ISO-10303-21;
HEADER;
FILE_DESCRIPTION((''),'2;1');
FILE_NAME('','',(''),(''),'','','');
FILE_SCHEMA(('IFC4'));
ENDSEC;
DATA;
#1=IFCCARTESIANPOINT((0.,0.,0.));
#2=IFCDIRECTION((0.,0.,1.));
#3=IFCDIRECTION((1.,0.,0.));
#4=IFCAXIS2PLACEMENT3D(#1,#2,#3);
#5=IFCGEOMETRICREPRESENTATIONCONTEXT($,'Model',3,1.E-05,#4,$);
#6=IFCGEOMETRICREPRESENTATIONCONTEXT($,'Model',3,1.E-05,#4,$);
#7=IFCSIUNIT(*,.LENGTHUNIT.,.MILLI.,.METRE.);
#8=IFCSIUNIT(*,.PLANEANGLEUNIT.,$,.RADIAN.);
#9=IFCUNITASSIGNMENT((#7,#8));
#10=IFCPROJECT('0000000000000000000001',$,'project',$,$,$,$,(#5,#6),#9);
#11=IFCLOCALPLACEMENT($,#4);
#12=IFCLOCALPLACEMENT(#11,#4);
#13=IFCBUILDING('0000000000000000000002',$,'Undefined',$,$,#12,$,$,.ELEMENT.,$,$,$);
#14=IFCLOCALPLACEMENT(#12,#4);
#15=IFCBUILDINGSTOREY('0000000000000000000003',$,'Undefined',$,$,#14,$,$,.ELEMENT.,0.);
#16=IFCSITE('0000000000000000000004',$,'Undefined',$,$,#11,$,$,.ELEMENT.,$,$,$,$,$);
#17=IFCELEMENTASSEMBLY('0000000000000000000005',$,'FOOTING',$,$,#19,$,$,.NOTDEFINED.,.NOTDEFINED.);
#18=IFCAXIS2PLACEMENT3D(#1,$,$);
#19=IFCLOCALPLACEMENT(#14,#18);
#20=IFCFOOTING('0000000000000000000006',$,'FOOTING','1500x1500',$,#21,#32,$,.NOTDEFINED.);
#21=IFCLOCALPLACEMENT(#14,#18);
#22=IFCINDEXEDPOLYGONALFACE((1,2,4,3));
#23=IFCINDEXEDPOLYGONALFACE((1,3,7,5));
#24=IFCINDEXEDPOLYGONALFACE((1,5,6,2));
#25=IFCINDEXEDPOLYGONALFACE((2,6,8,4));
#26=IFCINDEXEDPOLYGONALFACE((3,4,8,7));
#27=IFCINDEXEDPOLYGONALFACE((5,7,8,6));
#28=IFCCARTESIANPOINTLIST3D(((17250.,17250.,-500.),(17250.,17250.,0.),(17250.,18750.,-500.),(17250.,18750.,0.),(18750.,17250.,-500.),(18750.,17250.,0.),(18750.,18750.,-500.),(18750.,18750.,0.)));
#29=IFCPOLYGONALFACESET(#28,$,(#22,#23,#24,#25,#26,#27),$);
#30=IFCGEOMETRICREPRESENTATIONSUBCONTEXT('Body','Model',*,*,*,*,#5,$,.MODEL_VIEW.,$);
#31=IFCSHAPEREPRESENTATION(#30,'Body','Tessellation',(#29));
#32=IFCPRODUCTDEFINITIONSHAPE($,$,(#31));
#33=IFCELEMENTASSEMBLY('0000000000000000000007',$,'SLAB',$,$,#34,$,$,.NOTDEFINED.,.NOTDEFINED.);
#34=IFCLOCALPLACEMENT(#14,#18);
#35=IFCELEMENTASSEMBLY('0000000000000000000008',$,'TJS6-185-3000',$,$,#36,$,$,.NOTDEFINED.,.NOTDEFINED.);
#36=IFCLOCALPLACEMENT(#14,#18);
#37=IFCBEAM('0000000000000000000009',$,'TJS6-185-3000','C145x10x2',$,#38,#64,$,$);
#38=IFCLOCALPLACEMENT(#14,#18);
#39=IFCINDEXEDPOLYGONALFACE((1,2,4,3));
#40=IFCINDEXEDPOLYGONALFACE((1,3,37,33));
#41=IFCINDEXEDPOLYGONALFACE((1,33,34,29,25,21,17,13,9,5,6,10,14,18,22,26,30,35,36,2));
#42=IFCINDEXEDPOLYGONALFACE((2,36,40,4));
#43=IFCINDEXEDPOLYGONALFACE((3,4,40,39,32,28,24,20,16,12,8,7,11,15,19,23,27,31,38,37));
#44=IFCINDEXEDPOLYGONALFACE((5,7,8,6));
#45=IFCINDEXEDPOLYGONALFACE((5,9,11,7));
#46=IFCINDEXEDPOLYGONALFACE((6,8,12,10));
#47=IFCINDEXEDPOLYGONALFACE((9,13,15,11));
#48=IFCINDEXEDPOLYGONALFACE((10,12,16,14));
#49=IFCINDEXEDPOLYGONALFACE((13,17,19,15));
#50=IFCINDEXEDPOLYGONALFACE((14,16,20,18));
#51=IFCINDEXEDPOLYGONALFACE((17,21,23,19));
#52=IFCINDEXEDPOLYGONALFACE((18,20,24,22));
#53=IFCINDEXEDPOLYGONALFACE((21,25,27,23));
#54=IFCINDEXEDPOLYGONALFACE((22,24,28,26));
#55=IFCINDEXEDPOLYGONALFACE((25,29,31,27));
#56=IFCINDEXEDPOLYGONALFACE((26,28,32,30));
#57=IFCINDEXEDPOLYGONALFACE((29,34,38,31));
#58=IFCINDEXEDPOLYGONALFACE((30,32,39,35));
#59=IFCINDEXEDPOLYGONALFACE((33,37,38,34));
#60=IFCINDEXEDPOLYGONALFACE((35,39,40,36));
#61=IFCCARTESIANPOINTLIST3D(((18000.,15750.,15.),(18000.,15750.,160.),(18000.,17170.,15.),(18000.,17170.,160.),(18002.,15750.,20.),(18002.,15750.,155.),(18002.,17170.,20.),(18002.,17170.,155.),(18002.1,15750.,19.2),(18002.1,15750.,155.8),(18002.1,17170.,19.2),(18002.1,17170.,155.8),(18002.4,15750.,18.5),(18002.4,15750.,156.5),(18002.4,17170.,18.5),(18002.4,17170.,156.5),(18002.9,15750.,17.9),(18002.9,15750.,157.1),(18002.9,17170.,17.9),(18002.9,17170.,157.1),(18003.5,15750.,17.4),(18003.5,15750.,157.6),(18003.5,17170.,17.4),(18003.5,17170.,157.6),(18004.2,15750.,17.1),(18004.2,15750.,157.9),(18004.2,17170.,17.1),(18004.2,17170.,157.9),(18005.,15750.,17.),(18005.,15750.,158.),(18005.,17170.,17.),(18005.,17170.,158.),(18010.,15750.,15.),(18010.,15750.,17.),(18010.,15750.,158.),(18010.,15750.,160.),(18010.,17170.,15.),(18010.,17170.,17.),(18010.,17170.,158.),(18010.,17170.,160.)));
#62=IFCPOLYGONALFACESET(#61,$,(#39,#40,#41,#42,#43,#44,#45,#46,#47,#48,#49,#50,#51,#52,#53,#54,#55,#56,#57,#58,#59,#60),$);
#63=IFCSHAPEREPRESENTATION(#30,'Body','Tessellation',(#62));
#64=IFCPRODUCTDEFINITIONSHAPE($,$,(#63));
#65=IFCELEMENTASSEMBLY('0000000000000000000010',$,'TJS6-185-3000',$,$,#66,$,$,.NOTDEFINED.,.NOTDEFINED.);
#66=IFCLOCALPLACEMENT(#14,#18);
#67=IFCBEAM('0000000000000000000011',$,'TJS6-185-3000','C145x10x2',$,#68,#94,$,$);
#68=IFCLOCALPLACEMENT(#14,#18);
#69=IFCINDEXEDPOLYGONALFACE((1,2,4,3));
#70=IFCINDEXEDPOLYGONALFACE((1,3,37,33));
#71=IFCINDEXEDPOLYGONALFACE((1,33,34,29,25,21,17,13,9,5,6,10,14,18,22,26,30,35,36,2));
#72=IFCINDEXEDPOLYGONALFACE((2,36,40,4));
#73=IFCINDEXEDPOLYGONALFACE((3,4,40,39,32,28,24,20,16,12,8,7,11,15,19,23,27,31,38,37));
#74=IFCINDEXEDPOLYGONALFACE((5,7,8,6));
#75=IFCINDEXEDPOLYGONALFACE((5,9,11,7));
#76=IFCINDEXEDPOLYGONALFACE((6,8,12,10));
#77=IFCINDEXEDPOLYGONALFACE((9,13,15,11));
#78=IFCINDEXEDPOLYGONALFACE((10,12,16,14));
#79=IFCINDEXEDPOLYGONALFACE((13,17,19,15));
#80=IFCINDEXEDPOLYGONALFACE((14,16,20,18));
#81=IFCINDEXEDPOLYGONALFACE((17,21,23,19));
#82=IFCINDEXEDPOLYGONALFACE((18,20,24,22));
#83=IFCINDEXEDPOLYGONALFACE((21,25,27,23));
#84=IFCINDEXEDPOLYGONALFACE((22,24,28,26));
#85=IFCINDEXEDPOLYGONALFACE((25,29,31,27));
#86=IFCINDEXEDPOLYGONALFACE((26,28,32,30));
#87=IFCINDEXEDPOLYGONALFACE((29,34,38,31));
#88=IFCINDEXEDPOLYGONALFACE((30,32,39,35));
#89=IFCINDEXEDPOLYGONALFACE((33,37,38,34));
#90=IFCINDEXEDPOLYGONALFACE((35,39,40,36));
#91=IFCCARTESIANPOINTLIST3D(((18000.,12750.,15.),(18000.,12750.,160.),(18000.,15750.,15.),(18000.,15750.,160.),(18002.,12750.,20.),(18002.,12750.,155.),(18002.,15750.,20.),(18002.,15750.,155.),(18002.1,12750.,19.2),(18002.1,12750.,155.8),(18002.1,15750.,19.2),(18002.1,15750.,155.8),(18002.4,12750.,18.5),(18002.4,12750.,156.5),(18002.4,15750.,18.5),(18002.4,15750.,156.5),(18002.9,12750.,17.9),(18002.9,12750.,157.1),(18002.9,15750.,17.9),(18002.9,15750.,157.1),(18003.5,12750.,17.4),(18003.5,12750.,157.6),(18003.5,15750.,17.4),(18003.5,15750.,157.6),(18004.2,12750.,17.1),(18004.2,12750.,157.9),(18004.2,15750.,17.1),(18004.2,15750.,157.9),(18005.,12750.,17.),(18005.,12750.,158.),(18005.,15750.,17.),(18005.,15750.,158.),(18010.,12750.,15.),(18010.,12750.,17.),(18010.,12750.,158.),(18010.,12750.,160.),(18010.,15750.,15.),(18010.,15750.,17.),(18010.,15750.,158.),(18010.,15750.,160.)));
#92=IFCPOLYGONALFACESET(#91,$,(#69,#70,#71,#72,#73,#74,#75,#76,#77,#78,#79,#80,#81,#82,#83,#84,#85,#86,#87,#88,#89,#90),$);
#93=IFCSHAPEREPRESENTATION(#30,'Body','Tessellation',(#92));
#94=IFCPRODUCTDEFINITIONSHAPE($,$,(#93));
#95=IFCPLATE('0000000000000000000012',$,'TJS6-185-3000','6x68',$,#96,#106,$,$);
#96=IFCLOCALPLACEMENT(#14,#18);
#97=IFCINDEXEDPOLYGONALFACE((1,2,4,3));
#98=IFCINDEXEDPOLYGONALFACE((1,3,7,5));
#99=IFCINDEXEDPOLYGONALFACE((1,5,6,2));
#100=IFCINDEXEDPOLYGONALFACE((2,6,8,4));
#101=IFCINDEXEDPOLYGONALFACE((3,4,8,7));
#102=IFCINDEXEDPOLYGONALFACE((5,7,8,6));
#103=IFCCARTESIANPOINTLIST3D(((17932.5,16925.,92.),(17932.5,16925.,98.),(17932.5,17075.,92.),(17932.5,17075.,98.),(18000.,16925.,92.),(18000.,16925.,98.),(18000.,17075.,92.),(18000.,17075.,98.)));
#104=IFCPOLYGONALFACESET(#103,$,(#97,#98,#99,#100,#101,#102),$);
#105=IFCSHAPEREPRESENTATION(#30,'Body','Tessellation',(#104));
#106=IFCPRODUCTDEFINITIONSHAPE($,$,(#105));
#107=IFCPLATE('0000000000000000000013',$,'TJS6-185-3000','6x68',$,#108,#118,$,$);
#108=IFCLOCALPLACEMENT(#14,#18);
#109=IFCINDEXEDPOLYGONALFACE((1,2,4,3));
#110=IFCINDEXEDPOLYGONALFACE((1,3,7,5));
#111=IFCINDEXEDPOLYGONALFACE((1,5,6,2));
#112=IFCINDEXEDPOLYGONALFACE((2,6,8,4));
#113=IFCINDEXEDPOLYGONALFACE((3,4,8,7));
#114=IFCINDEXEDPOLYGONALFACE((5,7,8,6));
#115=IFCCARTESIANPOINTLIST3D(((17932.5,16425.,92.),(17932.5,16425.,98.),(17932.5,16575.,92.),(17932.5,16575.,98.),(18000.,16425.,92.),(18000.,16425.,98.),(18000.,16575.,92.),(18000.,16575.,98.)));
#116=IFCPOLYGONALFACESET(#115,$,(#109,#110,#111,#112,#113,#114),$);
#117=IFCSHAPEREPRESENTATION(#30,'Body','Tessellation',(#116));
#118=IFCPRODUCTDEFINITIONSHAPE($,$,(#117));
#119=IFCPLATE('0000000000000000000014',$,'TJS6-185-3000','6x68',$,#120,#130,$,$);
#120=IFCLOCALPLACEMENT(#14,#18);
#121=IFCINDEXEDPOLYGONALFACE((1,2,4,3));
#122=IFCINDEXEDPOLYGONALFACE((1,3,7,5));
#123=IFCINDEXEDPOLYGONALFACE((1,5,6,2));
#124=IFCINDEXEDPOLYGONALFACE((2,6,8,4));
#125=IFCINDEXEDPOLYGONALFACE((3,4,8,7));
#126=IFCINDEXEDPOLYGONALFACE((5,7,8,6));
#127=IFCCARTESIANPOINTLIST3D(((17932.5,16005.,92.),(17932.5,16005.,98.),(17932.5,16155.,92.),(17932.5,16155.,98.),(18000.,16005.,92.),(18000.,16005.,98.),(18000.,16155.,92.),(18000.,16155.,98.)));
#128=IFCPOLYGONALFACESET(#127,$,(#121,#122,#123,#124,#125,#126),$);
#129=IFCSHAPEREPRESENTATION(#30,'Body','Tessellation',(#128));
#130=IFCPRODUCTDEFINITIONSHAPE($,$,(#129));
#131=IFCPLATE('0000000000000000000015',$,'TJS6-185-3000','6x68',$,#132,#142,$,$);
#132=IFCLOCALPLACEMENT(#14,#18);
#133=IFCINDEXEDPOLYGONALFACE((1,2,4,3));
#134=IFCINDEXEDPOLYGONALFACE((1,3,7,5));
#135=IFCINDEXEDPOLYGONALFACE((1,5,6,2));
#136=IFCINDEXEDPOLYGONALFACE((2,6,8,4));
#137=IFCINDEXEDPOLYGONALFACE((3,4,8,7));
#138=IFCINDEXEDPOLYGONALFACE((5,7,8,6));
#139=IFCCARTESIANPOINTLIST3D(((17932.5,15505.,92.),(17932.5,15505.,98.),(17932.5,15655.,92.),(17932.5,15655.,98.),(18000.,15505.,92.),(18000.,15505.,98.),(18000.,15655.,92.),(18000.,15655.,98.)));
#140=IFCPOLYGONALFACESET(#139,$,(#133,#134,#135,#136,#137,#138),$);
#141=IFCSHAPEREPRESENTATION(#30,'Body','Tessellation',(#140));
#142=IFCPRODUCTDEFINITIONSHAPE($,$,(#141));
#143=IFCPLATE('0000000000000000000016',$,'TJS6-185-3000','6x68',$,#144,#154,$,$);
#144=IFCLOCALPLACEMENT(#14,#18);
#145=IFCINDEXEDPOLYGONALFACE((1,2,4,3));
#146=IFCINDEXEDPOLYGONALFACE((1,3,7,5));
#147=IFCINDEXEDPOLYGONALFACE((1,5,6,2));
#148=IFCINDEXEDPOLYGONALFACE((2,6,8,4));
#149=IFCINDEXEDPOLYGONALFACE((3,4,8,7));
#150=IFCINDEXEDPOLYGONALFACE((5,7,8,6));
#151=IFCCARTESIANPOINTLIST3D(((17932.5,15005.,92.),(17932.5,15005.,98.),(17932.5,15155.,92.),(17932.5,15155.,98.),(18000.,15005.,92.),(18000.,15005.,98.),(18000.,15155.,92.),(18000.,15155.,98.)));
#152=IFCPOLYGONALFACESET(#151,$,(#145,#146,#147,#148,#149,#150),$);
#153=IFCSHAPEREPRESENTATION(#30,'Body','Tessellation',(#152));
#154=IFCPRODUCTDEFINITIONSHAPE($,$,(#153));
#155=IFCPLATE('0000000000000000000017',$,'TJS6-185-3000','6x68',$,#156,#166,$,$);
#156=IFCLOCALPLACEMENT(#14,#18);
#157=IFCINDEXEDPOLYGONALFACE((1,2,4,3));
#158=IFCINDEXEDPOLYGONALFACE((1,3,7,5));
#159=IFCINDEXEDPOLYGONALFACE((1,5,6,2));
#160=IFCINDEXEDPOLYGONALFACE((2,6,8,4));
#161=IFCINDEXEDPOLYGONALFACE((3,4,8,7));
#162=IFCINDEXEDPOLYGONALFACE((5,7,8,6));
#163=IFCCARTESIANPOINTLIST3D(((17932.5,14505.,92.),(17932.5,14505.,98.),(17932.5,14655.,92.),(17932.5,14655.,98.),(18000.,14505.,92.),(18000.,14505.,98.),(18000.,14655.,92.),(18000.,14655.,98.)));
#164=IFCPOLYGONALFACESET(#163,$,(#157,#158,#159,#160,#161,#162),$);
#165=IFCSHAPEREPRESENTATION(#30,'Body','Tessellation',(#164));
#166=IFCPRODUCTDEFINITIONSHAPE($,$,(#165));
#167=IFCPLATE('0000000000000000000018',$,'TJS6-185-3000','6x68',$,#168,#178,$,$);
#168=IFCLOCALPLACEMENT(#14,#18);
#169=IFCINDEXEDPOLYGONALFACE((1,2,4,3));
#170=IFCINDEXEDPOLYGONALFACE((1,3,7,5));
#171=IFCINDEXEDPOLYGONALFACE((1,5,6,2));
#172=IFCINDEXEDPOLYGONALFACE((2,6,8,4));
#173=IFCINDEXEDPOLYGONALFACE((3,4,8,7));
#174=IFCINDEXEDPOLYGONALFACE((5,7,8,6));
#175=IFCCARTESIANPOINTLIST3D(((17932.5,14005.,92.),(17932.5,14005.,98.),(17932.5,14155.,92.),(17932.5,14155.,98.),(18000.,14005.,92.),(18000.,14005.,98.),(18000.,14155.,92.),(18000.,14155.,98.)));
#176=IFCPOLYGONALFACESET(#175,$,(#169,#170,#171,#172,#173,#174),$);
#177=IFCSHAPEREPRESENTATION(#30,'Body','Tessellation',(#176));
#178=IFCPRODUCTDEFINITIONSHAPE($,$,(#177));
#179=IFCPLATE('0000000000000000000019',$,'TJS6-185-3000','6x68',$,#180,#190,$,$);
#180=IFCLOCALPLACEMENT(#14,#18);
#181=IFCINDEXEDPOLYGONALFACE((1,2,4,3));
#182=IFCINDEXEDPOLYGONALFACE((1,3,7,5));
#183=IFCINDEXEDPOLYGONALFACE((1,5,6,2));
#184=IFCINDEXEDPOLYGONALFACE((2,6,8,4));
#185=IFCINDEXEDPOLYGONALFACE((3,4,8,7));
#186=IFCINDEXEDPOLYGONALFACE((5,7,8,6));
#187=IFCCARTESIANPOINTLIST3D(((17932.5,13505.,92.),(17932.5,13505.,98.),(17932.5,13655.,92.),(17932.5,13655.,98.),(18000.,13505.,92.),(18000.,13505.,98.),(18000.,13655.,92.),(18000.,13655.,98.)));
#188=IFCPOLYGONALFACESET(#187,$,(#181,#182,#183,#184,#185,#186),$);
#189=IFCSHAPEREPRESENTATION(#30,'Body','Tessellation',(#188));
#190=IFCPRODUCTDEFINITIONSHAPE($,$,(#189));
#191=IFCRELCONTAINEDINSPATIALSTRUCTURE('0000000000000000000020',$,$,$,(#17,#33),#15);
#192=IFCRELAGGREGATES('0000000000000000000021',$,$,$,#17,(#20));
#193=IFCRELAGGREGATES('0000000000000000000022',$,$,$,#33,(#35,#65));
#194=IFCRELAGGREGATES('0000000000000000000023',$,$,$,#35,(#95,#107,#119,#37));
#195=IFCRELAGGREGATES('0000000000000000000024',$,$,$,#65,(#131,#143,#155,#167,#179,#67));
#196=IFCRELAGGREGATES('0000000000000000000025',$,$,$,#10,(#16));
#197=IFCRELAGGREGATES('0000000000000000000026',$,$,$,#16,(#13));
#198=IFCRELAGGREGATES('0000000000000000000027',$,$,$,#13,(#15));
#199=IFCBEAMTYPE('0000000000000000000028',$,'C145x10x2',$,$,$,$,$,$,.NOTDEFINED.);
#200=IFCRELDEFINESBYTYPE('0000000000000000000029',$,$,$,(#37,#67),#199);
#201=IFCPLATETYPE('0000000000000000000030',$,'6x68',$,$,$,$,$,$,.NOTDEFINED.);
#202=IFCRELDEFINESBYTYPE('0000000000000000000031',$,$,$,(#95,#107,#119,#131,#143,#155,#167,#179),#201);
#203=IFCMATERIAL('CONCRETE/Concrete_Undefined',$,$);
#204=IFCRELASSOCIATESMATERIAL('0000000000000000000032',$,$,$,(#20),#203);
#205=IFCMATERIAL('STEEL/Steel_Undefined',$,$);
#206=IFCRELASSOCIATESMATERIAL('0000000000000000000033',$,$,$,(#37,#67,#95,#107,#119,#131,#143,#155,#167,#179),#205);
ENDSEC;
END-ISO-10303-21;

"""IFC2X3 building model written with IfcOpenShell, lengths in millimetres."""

from ifc_helpers import new_model, si_unit, frame, origin_with_axes, origin_2d_with_axis, place, context, subcontext, project, spatial, polyline, rectangle, u_section, outline, extrude, material, type_object, element, aggregate, save


model = new_model("IFC2X3")

# Units and contexts
model_context_1 = context("Model", 3, precision=1e-05, world=origin_with_axes())
model_context_2 = context("Model", 3, precision=1e-05, world=origin_with_axes())
body_context = subcontext(model_context_1, "Body", "Model", "MODEL_VIEW")
ifc_project = project(units=[si_unit("LENGTHUNIT", "METRE", prefix="MILLI"), si_unit("PLANEANGLEUNIT", "RADIAN")], contexts=[model_context_1, model_context_2])

# Site, building, storey
site_placement = place(None, origin_with_axes())
site = spatial("IfcSite", under=ifc_project, at=site_placement, Name="Undefined", CompositionType="ELEMENT")
building_placement = place(site_placement, origin_with_axes())
building = spatial("IfcBuilding", under=site, at=building_placement, Name="Undefined", CompositionType="ELEMENT")
storey_placement = place(building_placement, origin_with_axes())
storey = spatial("IfcBuildingStorey", under=building, at=storey_placement, Name="Undefined", CompositionType="ELEMENT", Elevation=0.0)

# Element assembly, footing
assembly_1_placement = place(storey_placement, origin_with_axes())
assembly_1 = element("IfcElementAssembly", 1, at=assembly_1_placement, inside=storey, Name="FOOTING", AssemblyPlace="NOTDEFINED", PredefinedType="NOTDEFINED")
ifc_material_1 = material(Name="CONCRETE/Concrete_Undefined")
footing_placement = place(assembly_1_placement, frame((18000.0, 18000.0, -500.0), z_axis=(0.0, 1.0, 0.0), x_axis=(0.0, 0.0, 1.0)))
footing = element("IfcFooting", 2, at=footing_placement, material=ifc_material_1, Name="FOOTING", Description="1500x1500", PredefinedType="NOTDEFINED", context=body_context, shape_type="SweptSolid", body=[
    extrude(rectangle(XDim=1500.0, YDim=1500.0, at=origin_2d_with_axis()), frame((500.0, 0.0, 0.0), z_axis=(-1.0, 0.0, 0.0), x_axis=(0.0, -1.0, 0.0)), (0.0, 0.0, 1.0), 500.0),
])
aggregate(assembly_1, [footing])

# Element assemblies, beams, plates
assembly_2_placement = place(storey_placement, origin_with_axes())
assembly_2 = element("IfcElementAssembly", 3, at=assembly_2_placement, inside=storey, Name="SLAB", AssemblyPlace="NOTDEFINED", PredefinedType="NOTDEFINED")
assembly_3_placement = place(assembly_2_placement, origin_with_axes())
assembly_3 = element("IfcElementAssembly", 4, at=assembly_3_placement, Name="TJS6-185-3000", AssemblyPlace="NOTDEFINED", PredefinedType="NOTDEFINED")
ifc_material_2 = material(Name="STEEL/Steel_Undefined")
beam_type = type_object("IfcBeamType", Name="C145x10x2", PredefinedType="NOTDEFINED")
beam_1_placement = place(assembly_3_placement, frame((18005.0, 15750.0, 87.5), z_axis=(0.0, 0.0, 1.0), x_axis=(0.0, 1.0, 0.0)))
beam_1 = element("IfcBeam", 5, at=beam_1_placement, type_object=beam_type, material=ifc_material_2, Name="TJS6-185-3000", Description="C145x10x2", context=body_context, shape_type="SweptSolid", body=[
    extrude(u_section(Depth=145.0, FlangeWidth=10.0, WebThickness=2.0, FlangeThickness=2.0, FilletRadius=3.0, at=origin_2d_with_axis()), frame((1420.0, 0.0, 0.0), z_axis=(-1.0, 0.0, 0.0), x_axis=(0.0, -1.0, 0.0)), (0.0, 0.0, 1.0), 1420.0),
])
assembly_4_placement = place(assembly_2_placement, origin_with_axes())
assembly_4 = element("IfcElementAssembly", 6, at=assembly_4_placement, Name="TJS6-185-3000", AssemblyPlace="NOTDEFINED", PredefinedType="NOTDEFINED")
beam_2_placement = place(assembly_4_placement, frame((18005.0, 12750.0, 87.5), z_axis=(0.0, 0.0, 1.0), x_axis=(0.0, 1.0, 0.0)))
beam_2 = element("IfcBeam", 7, at=beam_2_placement, type_object=beam_type, material=ifc_material_2, Name="TJS6-185-3000", Description="C145x10x2", context=body_context, shape_type="SweptSolid", body=[
    extrude(u_section(Depth=145.0, FlangeWidth=10.0, WebThickness=2.0, FlangeThickness=2.0, FilletRadius=3.0, at=origin_2d_with_axis()), frame((3000.0, 0.0, 0.0), z_axis=(-1.0, 0.0, 0.0), x_axis=(0.0, -1.0, 0.0)), (0.0, 0.0, 1.0), 3000.0),
])
plate_type_1 = type_object("IfcPlateType", Name="6x68", PredefinedType="NOTDEFINED")
plate_1_placement = place(assembly_3_placement, frame((18000.0, 16925.0, 95.0), z_axis=(0.0, 0.0, 1.0), x_axis=(0.0, 1.0, 0.0)))
plate_1 = element("IfcPlate", 8, at=plate_1_placement, type_object=plate_type_1, material=ifc_material_2, Name="TJS6-185-3000", Description="6x68", context=body_context, shape_type="SweptSolid", body=[
    extrude(outline(polyline([(0.0, 0.0), (150.0, 0.0), (150.0, 67.5), (0.0, 67.5), (0.0, 0.0)])), frame((0.0, 0.0, -3.0), z_axis=(0.0, 0.0, 1.0), x_axis=(1.0, 0.0, 0.0)), (0.0, 0.0, 1.0), 6.0),
])
plate_2_placement = place(assembly_3_placement, frame((18000.0, 16425.0, 95.0), z_axis=(0.0, 0.0, 1.0), x_axis=(0.0, 1.0, 0.0)))
plate_2 = element("IfcPlate", 9, at=plate_2_placement, type_object=plate_type_1, material=ifc_material_2, Name="TJS6-185-3000", Description="6x68", context=body_context, shape_type="SweptSolid", body=[
    extrude(outline(polyline([(0.0, 0.0), (150.0, 0.0), (150.0, 67.5), (0.0, 67.5), (0.0, 0.0)])), frame((0.0, 0.0, -3.0), z_axis=(0.0, 0.0, 1.0), x_axis=(1.0, 0.0, 0.0)), (0.0, 0.0, 1.0), 6.0),
])
plate_3_placement = place(assembly_3_placement, frame((18000.0, 16005.0, 95.0), z_axis=(0.0, 0.0, 1.0), x_axis=(0.0, 1.0, 0.0)))
plate_3 = element("IfcPlate", 10, at=plate_3_placement, type_object=plate_type_1, material=ifc_material_2, Name="TJS6-185-3000", Description="6x68", context=body_context, shape_type="SweptSolid", body=[
    extrude(outline(polyline([(0.0, 0.0), (150.0, 0.0), (150.0, 67.5), (0.0, 67.5), (0.0, 0.0)])), frame((0.0, 0.0, -3.0), z_axis=(0.0, 0.0, 1.0), x_axis=(1.0, 0.0, 0.0)), (0.0, 0.0, 1.0), 6.0),
])
plate_4_placement = place(assembly_4_placement, frame((18000.0, 15505.0, 95.0), z_axis=(0.0, 0.0, 1.0), x_axis=(0.0, 1.0, 0.0)))
plate_4 = element("IfcPlate", 11, at=plate_4_placement, type_object=plate_type_1, material=ifc_material_2, Name="TJS6-185-3000", Description="6x68", context=body_context, shape_type="SweptSolid", body=[
    extrude(outline(polyline([(0.0, 0.0), (150.0, 0.0), (150.0, 67.5), (0.0, 67.5), (0.0, 0.0)])), frame((0.0, 0.0, -3.0), z_axis=(0.0, 0.0, 1.0), x_axis=(1.0, 0.0, 0.0)), (0.0, 0.0, 1.0), 6.0),
])
plate_5_placement = place(assembly_4_placement, frame((18000.0, 15005.0, 95.0), z_axis=(0.0, 0.0, 1.0), x_axis=(0.0, 1.0, 0.0)))
plate_5 = element("IfcPlate", 12, at=plate_5_placement, type_object=plate_type_1, material=ifc_material_2, Name="TJS6-185-3000", Description="6x68", context=body_context, shape_type="SweptSolid", body=[
    extrude(outline(polyline([(0.0, 0.0), (150.0, 0.0), (150.0, 67.5), (0.0, 67.5), (0.0, 0.0)])), frame((0.0, 0.0, -3.0), z_axis=(0.0, 0.0, 1.0), x_axis=(1.0, 0.0, 0.0)), (0.0, 0.0, 1.0), 6.0),
])
plate_6_placement = place(assembly_4_placement, frame((18000.0, 14505.0, 95.0), z_axis=(0.0, 0.0, 1.0), x_axis=(0.0, 1.0, 0.0)))
plate_6 = element("IfcPlate", 13, at=plate_6_placement, type_object=plate_type_1, material=ifc_material_2, Name="TJS6-185-3000", Description="6x68", context=body_context, shape_type="SweptSolid", body=[
    extrude(outline(polyline([(0.0, 0.0), (150.0, 0.0), (150.0, 67.5), (0.0, 67.5), (0.0, 0.0)])), frame((0.0, 0.0, -3.0), z_axis=(0.0, 0.0, 1.0), x_axis=(1.0, 0.0, 0.0)), (0.0, 0.0, 1.0), 6.0),
])
plate_7_placement = place(assembly_4_placement, frame((18000.0, 14005.0, 95.0), z_axis=(0.0, 0.0, 1.0), x_axis=(0.0, 1.0, 0.0)))
plate_7 = element("IfcPlate", 14, at=plate_7_placement, type_object=plate_type_1, material=ifc_material_2, Name="TJS6-185-3000", Description="6x68", context=body_context, shape_type="SweptSolid", body=[
    extrude(outline(polyline([(0.0, 0.0), (150.0, 0.0), (150.0, 67.5), (0.0, 67.5), (0.0, 0.0)])), frame((0.0, 0.0, -3.0), z_axis=(0.0, 0.0, 1.0), x_axis=(1.0, 0.0, 0.0)), (0.0, 0.0, 1.0), 6.0),
])
plate_8_placement = place(assembly_4_placement, frame((18000.0, 13505.0, 95.0), z_axis=(0.0, 0.0, 1.0), x_axis=(0.0, 1.0, 0.0)))
plate_8 = element("IfcPlate", 15, at=plate_8_placement, type_object=plate_type_1, material=ifc_material_2, Name="TJS6-185-3000", Description="6x68", context=body_context, shape_type="SweptSolid", body=[
    extrude(outline(polyline([(0.0, 0.0), (150.0, 0.0), (150.0, 67.5), (0.0, 67.5), (0.0, 0.0)])), frame((0.0, 0.0, -3.0), z_axis=(0.0, 0.0, 1.0), x_axis=(1.0, 0.0, 0.0)), (0.0, 0.0, 1.0), 6.0),
])
aggregate(assembly_2, [assembly_3, assembly_4])

aggregate(assembly_3, [plate_1, plate_2, plate_3, beam_1])
aggregate(assembly_4, [plate_4, plate_5, plate_6, plate_7, plate_8, beam_2])

save(model, "model.ifc")
